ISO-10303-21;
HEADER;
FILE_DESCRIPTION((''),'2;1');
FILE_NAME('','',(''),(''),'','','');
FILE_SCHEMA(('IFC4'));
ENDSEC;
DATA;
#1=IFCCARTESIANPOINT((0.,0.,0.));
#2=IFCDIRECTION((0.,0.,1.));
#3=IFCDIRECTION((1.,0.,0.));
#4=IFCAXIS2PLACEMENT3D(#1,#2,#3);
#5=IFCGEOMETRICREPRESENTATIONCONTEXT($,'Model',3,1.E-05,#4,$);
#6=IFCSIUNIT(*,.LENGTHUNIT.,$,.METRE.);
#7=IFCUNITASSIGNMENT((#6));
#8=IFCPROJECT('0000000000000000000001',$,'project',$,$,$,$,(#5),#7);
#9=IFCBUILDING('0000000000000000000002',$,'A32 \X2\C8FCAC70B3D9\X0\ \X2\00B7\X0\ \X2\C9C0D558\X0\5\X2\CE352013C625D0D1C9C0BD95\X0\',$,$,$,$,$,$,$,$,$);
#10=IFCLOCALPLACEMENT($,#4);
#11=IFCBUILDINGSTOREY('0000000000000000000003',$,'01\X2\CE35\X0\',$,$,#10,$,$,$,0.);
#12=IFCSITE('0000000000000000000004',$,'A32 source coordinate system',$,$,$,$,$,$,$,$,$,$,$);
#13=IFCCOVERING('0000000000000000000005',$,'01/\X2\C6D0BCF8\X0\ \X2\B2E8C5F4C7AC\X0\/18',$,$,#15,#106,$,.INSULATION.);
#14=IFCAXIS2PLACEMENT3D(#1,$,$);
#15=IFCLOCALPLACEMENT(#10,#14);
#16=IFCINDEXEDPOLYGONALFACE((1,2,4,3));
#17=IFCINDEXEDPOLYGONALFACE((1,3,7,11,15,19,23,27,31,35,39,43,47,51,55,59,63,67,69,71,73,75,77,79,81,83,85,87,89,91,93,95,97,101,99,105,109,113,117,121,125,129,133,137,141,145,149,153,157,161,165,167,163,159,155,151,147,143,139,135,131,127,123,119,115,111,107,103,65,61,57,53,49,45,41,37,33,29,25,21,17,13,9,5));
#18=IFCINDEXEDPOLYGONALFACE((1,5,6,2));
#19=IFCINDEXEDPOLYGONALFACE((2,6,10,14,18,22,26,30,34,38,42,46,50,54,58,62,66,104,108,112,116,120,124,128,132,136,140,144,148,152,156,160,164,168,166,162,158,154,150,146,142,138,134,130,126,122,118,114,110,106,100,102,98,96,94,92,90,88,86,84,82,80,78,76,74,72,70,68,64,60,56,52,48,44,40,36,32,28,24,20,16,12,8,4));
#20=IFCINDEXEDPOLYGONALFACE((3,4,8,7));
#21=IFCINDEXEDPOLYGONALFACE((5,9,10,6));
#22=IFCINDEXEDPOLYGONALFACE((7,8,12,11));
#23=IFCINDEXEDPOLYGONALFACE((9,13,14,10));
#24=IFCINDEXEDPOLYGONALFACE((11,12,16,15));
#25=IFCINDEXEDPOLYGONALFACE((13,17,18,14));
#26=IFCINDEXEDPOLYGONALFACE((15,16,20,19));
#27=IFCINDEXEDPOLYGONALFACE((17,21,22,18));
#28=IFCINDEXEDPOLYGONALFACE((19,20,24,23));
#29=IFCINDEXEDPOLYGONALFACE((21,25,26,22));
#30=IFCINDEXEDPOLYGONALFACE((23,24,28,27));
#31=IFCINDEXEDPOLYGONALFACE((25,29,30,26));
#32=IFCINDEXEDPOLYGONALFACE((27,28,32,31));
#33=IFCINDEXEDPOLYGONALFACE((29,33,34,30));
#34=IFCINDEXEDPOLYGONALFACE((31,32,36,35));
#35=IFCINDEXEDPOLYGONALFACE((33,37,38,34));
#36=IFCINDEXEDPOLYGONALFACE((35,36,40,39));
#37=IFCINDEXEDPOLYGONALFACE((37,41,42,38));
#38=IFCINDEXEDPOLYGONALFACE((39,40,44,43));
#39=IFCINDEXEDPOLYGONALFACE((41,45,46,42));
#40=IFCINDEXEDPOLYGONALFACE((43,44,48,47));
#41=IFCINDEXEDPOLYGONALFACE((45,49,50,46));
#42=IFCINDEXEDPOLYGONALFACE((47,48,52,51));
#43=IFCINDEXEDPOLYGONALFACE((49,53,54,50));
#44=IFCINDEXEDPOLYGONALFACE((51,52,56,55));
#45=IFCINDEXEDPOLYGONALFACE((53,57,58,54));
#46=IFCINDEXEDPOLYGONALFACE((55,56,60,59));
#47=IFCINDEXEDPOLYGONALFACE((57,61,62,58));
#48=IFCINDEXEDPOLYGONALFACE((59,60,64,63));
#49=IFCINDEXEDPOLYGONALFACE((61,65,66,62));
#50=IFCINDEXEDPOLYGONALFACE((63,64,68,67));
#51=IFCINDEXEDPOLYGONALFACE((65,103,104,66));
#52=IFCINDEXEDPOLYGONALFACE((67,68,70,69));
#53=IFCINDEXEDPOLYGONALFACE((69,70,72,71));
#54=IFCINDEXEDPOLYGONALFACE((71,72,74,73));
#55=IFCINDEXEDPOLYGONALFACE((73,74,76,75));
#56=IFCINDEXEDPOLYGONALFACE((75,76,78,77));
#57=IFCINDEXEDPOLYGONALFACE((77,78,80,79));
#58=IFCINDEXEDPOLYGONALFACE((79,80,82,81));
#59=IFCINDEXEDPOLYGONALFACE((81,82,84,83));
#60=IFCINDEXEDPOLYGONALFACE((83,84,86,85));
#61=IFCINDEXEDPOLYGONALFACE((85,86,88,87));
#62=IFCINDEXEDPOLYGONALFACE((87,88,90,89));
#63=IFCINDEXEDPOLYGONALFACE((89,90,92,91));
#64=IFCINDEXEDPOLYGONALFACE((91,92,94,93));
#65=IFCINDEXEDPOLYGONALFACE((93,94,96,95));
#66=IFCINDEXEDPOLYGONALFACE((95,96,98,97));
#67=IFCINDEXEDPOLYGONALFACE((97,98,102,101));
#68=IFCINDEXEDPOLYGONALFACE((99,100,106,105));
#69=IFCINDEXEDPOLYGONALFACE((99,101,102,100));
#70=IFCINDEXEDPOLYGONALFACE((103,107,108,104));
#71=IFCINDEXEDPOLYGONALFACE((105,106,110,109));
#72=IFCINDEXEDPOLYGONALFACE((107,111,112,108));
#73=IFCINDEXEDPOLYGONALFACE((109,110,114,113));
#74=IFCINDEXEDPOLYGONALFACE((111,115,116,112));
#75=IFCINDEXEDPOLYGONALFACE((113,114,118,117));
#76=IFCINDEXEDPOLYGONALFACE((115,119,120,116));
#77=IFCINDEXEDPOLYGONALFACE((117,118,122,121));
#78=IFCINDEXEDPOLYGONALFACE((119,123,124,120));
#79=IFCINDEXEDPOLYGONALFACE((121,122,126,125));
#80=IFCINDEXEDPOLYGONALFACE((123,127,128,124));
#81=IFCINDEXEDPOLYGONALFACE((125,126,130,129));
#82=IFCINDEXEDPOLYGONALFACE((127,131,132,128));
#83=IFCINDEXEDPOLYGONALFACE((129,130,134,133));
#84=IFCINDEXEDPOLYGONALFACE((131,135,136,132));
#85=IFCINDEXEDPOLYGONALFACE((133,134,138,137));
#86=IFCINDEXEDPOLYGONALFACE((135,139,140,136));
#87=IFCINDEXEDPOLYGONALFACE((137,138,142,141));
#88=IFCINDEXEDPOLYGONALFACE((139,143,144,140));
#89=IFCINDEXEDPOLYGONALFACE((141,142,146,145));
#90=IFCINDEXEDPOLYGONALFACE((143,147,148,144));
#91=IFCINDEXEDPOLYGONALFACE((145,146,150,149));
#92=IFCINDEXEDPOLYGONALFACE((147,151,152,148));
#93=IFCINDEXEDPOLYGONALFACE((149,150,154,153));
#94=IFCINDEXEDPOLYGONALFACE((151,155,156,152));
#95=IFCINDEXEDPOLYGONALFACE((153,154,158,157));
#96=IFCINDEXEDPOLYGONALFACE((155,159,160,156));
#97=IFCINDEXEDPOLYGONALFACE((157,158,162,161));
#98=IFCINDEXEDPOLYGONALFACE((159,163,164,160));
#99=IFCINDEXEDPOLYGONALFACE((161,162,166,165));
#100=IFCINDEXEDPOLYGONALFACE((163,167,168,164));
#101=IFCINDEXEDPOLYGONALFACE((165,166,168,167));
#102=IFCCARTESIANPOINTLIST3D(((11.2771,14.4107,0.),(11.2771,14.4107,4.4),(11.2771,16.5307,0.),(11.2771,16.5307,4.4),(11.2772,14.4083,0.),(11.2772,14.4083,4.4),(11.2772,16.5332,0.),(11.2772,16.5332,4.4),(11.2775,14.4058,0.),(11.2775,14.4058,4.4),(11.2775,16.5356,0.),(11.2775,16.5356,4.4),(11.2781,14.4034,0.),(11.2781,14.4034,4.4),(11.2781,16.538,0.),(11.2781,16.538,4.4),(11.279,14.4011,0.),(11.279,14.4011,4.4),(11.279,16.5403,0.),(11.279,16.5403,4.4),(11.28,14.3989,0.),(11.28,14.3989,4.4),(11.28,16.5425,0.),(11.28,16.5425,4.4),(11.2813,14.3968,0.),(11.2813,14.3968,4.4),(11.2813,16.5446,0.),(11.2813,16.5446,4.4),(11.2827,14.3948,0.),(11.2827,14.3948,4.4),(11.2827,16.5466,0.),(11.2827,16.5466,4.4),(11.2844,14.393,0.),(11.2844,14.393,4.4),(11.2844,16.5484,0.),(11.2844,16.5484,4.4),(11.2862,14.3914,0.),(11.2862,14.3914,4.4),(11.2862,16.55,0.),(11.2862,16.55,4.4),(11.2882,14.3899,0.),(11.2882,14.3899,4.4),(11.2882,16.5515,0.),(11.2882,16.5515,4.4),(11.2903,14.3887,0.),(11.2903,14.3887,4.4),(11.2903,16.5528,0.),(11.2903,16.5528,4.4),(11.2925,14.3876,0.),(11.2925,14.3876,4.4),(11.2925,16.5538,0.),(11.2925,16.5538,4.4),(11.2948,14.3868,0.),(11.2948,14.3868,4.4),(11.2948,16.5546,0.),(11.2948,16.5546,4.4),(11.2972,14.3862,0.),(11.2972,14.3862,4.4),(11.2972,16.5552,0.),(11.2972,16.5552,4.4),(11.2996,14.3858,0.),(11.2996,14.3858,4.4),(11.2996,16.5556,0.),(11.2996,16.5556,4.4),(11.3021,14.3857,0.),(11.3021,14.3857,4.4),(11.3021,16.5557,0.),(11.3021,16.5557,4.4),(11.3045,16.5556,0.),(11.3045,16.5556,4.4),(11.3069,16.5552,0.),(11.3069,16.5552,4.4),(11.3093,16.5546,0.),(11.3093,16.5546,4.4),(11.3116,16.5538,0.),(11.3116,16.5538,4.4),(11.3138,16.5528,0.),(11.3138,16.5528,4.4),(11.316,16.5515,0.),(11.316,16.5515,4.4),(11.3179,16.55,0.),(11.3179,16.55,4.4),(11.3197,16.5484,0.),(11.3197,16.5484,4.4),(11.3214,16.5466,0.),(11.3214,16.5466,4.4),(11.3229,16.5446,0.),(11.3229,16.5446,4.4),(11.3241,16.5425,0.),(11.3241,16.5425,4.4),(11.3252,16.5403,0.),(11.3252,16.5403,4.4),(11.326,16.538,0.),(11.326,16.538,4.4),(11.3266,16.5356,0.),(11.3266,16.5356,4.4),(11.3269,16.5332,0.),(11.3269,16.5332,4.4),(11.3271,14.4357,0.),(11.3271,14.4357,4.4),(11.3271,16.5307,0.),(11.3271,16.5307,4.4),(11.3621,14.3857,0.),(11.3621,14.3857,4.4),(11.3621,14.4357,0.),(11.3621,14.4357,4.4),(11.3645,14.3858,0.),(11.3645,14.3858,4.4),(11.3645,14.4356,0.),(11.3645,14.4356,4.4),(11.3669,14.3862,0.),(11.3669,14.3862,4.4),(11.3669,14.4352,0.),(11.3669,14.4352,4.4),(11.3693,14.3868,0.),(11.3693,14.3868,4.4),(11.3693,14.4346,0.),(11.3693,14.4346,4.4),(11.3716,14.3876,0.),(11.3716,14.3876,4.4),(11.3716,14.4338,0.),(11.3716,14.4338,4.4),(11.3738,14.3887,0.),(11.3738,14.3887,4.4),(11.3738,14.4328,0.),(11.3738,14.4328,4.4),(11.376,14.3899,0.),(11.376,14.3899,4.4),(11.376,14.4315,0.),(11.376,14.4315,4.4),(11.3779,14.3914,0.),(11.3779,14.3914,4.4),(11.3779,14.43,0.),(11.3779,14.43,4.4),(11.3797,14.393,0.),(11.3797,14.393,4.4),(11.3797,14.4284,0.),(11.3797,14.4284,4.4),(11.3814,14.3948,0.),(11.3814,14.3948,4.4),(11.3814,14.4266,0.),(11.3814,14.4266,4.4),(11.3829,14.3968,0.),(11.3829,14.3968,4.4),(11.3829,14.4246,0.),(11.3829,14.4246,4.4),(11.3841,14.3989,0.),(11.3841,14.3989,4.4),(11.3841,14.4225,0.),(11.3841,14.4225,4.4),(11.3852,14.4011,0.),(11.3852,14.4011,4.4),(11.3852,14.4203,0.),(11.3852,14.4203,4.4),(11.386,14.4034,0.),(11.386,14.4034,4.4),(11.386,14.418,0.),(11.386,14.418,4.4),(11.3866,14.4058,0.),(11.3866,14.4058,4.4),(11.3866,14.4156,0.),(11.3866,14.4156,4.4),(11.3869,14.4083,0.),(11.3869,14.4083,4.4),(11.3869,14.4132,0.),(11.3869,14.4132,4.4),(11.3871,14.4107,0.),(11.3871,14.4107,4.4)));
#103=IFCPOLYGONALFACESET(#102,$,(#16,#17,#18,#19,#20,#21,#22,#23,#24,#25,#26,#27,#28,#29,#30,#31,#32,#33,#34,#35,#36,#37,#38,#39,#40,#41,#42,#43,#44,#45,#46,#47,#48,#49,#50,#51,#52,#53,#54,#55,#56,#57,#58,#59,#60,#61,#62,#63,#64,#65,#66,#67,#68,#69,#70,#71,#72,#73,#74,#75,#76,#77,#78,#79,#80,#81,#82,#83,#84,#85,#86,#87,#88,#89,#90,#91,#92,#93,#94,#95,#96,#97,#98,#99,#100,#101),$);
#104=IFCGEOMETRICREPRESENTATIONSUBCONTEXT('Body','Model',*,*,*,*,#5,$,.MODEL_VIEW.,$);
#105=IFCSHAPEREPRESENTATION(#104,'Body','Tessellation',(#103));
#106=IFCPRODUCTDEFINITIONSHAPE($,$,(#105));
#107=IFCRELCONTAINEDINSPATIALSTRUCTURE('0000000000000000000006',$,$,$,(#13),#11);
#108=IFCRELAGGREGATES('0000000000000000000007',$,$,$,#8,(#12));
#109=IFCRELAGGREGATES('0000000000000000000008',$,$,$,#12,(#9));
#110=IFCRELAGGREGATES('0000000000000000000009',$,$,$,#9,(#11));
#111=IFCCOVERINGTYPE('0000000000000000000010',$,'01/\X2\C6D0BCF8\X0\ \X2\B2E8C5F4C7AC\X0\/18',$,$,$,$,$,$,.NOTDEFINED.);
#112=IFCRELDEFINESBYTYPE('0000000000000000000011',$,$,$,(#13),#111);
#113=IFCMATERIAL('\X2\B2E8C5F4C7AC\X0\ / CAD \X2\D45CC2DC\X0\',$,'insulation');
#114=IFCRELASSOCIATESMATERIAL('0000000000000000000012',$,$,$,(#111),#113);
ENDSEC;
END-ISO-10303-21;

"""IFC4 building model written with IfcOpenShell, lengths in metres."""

from ifc_helpers import new_model, si_unit, origin, origin_with_axes, place, context, subcontext, project, spatial, polyline, outline, extrude, source, transform, mapped, material, type_object, type_shapes, element, save


model = new_model("IFC4")

# Units and contexts
model_context = context("Model", 3, precision=1e-05, world=origin_with_axes())
body_context = subcontext(model_context, "Body", "Model", "MODEL_VIEW")
ifc_project = project(units=[si_unit("LENGTHUNIT", "METRE")], contexts=[model_context])

# Site, building, storey
site = spatial("IfcSite", under=ifc_project, Name="A32 source coordinate system")
building = spatial("IfcBuilding", under=site, Name="A32 주거동 · 지하5층–옥탑지붕")
storey_placement = place(None, origin_with_axes())
storey = spatial("IfcBuildingStorey", under=building, at=storey_placement, Name="01층", Elevation=0.0)

# Covering
ifc_material = material(Name="단열재 / CAD 표시", Category="insulation")
covering_type_1 = type_object("IfcCoveringType", Name="01/원본 단열재/18", PredefinedType="NOTDEFINED", material=ifc_material)
shared_shape_1 = source(origin(), body_context, "Body", "SweptSolid", [
    extrude(outline(polyline([(11.279, 16.5403), (11.28, 16.5425), (11.2813, 16.5446), (11.2827, 16.5466), (11.2844, 16.5484), (11.2862, 16.55), (11.2882, 16.5515), (11.2903, 16.5528), (11.2925, 16.5538), (11.2948, 16.5546), (11.2972, 16.5552), (11.2996, 16.5556), (11.3021, 16.5557), (11.3045, 16.5556), (11.3069, 16.5552), (11.3093, 16.5546), (11.3116, 16.5538), (11.3138, 16.5528), (11.316, 16.5515), (11.3179, 16.55), (11.3197, 16.5484), (11.3214, 16.5466), (11.3229, 16.5446), (11.3241, 16.5425), (11.3252, 16.5403), (11.326, 16.538), (11.3266, 16.5356), (11.3269, 16.5332), (11.3271, 16.5307), (11.3271, 14.4357), (11.3621, 14.4357), (11.3645, 14.4356), (11.3669, 14.4352), (11.3693, 14.4346), (11.3716, 14.4338), (11.3738, 14.4328), (11.376, 14.4315), (11.3779, 14.43), (11.3797, 14.4284), (11.3814, 14.4266), (11.3829, 14.4246), (11.3841, 14.4225), (11.3852, 14.4203), (11.386, 14.418), (11.3866, 14.4156), (11.3869, 14.4132), (11.3871, 14.4107), (11.3869, 14.4083), (11.3866, 14.4058), (11.386, 14.4034), (11.3852, 14.4011), (11.3841, 14.3989), (11.3829, 14.3968), (11.3814, 14.3948), (11.3797, 14.393), (11.3779, 14.3914), (11.376, 14.3899), (11.3738, 14.3887), (11.3716, 14.3876), (11.3693, 14.3868), (11.3669, 14.3862), (11.3645, 14.3858), (11.3621, 14.3857), (11.3021, 14.3857), (11.2996, 14.3858), (11.2972, 14.3862), (11.2948, 14.3868), (11.2925, 14.3876), (11.2903, 14.3887), (11.2882, 14.3899), (11.2862, 14.3914), (11.2844, 14.393), (11.2827, 14.3948), (11.2813, 14.3968), (11.28, 14.3989), (11.279, 14.4011), (11.2781, 14.4034), (11.2775, 14.4058), (11.2772, 14.4083), (11.2771, 14.4107), (11.2771, 16.5307), (11.2772, 16.5332), (11.2775, 16.5356), (11.2781, 16.538), (11.279, 16.5403)])), origin(), (0.0, 0.0, 1.0), 4.4),
])
type_shapes(covering_type_1, [shared_shape_1])
covering_1_placement = place(storey_placement, origin_with_axes())
element("IfcCovering", 1, at=covering_1_placement, inside=storey, type_object=covering_type_1, Name="01/원본 단열재/18", PredefinedType="INSULATION", context=body_context, shape_type="MappedRepresentation", body=[
    mapped(shared_shape_1, transform((0.0, 0.0, 0.0), scale=1.0)),
])

save(model, "model.ifc")
